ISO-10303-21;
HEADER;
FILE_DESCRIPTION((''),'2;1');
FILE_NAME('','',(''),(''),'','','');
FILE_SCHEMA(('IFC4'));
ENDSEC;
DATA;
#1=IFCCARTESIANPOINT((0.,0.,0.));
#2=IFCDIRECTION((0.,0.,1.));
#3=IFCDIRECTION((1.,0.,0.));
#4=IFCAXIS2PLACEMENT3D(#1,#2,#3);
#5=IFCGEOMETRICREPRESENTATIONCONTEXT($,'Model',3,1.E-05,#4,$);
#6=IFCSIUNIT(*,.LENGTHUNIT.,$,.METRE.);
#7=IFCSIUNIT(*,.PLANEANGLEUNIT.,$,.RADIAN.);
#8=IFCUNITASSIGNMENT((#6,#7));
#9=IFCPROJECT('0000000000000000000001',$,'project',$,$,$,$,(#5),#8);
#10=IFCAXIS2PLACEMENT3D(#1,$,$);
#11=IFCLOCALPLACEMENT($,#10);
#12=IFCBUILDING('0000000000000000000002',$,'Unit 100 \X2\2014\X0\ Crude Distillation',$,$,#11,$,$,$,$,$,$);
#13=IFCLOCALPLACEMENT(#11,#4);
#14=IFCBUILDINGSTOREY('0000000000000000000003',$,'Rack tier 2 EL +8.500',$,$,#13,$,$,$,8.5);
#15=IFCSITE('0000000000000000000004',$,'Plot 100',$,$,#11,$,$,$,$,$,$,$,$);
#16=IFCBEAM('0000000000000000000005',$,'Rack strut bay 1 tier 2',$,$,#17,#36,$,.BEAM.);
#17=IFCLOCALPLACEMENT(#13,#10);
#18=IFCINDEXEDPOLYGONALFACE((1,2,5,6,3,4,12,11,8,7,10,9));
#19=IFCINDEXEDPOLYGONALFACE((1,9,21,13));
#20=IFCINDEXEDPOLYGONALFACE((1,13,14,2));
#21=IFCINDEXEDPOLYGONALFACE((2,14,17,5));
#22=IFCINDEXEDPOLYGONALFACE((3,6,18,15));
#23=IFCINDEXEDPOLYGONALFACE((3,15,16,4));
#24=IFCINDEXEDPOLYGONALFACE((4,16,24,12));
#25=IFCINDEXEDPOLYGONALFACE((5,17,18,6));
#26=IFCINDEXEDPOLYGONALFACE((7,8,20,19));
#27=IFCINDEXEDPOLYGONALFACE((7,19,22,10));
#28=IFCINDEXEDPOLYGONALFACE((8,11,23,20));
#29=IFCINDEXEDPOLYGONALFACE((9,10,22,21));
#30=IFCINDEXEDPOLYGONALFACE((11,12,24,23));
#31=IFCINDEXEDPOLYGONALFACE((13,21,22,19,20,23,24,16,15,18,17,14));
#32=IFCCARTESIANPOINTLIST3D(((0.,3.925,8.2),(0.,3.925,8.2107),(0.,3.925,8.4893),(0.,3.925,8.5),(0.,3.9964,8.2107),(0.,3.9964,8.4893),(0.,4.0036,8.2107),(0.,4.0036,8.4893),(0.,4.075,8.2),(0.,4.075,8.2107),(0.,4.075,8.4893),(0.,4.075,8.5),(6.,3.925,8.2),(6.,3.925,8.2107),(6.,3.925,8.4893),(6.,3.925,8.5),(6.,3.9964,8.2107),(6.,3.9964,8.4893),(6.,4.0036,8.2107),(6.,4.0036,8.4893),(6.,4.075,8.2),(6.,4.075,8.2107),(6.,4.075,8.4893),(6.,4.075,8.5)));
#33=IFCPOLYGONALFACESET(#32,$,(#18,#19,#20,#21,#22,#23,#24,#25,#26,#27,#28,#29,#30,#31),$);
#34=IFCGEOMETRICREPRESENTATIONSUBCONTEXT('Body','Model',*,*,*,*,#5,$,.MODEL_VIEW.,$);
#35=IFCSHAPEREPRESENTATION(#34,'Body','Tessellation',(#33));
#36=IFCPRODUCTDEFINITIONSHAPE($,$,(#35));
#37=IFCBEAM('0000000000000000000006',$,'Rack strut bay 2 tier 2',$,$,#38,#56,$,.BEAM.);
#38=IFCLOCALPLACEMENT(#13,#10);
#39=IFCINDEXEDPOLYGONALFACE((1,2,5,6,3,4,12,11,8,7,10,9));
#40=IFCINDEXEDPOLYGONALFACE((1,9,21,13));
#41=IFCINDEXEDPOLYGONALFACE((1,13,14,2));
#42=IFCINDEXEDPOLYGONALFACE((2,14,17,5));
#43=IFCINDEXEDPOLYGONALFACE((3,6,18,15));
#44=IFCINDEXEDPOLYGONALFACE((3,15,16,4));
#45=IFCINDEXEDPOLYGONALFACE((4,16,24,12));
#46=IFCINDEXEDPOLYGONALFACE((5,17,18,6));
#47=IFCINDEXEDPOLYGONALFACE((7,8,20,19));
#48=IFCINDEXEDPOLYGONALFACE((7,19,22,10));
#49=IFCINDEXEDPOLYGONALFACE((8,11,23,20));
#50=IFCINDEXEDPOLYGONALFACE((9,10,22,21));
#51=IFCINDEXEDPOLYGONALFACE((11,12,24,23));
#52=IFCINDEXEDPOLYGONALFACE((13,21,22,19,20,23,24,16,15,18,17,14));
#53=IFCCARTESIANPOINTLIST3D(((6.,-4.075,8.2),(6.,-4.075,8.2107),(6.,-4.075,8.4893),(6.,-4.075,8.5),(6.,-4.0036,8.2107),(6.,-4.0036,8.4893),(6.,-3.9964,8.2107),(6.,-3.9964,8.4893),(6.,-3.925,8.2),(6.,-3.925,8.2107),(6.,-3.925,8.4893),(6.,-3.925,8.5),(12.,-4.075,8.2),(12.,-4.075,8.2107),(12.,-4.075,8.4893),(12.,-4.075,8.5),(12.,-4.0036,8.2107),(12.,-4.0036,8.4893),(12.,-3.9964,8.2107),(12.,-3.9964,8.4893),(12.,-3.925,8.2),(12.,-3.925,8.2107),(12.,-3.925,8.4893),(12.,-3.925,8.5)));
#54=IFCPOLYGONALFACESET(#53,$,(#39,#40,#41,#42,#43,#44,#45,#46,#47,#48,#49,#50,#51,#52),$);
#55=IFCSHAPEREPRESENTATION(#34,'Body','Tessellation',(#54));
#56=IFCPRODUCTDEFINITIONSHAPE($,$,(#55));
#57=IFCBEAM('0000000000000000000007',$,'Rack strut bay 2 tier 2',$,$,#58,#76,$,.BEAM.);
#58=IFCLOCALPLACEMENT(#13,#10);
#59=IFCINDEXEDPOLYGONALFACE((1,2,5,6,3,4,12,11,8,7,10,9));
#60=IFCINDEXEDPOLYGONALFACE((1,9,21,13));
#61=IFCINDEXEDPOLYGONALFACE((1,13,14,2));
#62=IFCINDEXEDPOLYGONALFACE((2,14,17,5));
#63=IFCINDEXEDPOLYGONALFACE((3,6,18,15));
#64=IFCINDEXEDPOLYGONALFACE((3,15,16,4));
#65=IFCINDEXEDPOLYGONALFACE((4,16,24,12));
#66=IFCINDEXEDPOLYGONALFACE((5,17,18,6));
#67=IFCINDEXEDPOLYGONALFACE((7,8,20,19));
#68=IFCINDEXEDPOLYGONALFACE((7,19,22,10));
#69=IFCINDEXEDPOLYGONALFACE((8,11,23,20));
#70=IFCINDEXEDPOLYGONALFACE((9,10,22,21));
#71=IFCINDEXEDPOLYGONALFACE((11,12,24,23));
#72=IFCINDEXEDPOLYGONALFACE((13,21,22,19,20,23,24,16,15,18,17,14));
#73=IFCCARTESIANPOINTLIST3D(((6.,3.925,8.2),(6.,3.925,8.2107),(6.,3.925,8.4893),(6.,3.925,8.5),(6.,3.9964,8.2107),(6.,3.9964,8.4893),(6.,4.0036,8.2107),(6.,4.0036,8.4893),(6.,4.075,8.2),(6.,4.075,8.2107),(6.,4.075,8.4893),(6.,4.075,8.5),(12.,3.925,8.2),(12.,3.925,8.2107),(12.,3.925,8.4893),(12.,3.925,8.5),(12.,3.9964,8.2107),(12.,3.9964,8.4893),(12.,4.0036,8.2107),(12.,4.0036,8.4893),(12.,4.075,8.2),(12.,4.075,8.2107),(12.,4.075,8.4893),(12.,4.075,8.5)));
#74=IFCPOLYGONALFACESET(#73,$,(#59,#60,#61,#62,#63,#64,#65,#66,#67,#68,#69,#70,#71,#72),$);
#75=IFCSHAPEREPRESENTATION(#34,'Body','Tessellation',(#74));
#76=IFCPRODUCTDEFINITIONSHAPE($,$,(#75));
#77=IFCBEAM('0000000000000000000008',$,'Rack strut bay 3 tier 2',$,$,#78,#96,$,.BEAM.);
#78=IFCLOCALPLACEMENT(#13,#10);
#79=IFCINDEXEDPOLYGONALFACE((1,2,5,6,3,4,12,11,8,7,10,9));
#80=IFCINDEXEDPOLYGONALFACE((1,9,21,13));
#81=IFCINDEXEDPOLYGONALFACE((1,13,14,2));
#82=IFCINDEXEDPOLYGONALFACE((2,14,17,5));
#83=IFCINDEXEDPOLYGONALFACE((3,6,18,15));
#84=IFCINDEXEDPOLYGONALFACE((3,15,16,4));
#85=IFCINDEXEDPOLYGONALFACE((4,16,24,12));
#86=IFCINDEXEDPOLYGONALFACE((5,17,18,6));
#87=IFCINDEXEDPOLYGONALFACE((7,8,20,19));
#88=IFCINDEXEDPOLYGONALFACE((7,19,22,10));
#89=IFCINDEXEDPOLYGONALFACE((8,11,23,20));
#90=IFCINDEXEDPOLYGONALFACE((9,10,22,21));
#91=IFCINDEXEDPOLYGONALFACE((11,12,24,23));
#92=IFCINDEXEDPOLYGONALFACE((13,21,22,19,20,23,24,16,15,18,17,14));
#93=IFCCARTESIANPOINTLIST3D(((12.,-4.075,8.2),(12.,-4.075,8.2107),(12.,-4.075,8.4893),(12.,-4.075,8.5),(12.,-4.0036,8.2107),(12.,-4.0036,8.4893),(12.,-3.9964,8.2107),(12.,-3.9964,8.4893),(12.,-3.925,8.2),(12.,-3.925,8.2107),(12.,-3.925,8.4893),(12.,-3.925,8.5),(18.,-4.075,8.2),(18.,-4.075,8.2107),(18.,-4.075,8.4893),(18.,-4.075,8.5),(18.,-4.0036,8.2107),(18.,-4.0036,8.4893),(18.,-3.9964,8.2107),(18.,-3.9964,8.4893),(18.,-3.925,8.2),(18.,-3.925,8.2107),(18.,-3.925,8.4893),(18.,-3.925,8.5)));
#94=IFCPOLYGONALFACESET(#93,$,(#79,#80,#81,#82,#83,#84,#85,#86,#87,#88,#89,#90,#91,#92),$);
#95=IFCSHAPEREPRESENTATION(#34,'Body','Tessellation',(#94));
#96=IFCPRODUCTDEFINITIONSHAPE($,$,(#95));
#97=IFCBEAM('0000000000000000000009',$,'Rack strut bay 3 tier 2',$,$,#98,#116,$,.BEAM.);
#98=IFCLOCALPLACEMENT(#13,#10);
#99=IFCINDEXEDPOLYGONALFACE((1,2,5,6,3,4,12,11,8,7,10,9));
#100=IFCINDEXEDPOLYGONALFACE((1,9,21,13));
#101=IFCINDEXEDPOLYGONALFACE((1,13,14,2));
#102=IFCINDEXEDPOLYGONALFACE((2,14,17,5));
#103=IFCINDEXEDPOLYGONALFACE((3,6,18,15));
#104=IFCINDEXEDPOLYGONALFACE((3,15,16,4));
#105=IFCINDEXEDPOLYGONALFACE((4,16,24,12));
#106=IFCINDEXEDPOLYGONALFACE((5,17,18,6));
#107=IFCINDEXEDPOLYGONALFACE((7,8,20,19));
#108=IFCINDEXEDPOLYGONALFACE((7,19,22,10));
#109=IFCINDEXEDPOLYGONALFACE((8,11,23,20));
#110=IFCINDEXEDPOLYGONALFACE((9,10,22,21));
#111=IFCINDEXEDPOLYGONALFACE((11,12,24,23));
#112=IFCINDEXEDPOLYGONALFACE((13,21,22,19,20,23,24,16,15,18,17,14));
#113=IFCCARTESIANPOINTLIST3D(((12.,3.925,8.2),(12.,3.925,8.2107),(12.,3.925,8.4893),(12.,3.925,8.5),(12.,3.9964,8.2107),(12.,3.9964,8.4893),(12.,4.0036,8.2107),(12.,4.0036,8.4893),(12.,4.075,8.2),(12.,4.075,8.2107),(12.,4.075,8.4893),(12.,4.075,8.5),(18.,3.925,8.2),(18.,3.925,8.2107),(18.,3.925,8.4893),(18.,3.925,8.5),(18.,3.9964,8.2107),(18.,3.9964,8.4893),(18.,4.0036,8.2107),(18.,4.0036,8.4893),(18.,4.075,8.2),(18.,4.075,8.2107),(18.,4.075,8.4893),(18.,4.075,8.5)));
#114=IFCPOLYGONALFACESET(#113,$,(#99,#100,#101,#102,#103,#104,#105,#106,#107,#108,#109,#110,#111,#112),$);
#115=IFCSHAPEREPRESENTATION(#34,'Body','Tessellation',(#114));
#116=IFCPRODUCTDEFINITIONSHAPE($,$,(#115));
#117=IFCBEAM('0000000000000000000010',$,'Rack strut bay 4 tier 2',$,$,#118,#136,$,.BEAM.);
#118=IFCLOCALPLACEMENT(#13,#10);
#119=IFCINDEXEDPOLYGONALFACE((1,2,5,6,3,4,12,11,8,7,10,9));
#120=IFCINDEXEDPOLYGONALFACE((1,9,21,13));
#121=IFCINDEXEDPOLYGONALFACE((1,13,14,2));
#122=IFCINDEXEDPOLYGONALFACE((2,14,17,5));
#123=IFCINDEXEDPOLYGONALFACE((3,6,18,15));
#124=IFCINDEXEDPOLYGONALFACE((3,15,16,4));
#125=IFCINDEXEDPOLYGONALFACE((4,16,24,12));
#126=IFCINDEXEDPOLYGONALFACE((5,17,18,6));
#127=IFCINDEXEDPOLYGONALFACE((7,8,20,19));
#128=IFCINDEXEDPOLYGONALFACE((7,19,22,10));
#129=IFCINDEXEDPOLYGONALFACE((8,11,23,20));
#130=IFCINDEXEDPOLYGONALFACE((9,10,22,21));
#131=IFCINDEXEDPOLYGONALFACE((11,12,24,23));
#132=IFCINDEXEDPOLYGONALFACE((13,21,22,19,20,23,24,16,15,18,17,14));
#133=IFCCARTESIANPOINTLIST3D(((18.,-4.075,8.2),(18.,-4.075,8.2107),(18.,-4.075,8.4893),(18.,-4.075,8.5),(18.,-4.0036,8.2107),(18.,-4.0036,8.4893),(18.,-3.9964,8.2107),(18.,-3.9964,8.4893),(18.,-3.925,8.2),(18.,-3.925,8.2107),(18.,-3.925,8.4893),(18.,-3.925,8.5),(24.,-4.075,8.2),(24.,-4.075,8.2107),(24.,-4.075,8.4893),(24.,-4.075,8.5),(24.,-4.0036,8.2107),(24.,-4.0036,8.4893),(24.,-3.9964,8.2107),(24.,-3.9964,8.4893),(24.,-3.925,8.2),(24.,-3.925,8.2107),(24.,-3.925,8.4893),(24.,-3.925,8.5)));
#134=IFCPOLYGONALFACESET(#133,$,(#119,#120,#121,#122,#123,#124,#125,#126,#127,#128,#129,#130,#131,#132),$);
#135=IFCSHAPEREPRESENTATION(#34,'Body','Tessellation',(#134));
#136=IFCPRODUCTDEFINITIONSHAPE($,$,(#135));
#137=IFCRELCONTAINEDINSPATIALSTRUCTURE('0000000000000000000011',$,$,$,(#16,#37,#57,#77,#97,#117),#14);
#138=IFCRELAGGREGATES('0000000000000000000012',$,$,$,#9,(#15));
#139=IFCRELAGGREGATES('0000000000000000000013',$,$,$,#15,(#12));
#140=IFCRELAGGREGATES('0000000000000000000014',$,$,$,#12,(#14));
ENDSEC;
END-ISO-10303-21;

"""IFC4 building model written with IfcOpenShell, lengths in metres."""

from ifc_helpers import new_model, si_unit, frame, origin, origin_with_axes, origin_2d, place, context, subcontext, project, spatial, i_section, extrude, element, save


model = new_model("IFC4")

# Units and contexts
model_context = context("Model", 3, precision=1e-05, world=origin_with_axes())
body_context = subcontext(model_context, "Body", "Model", "MODEL_VIEW")
ifc_project = project(units=[si_unit("LENGTHUNIT", "METRE"), si_unit("PLANEANGLEUNIT", "RADIAN")], contexts=[model_context])

# Site, building, storey
placement = place(None, origin())
site = spatial("IfcSite", under=ifc_project, at=placement, Name="Plot 100")
building = spatial("IfcBuilding", under=site, at=placement, Name="Unit 100 — Crude Distillation")
storey_placement = place(placement, origin_with_axes())
storey = spatial("IfcBuildingStorey", under=building, at=storey_placement, Name="Rack tier 2 EL +8.500", Elevation=8.5)

# Beams
beam_1_placement = place(storey_placement, origin_with_axes())
element("IfcBeam", 1, at=beam_1_placement, inside=storey, Name="Rack strut bay 1 tier 2", PredefinedType="BEAM", context=body_context, shape_type="SweptSolid", body=[
    extrude(i_section(OverallWidth=0.15, OverallDepth=0.3, WebThickness=0.0071, FlangeThickness=0.0107, at=origin_2d()), frame((0.0, 4.0, 8.35), z_axis=(1.0, 0.0, 0.0), x_axis=(0.0, 1.0, 0.0)), (0.0, 0.0, 1.0), 6.0),
])
beam_2_placement = place(storey_placement, origin_with_axes())
element("IfcBeam", 2, at=beam_2_placement, inside=storey, Name="Rack strut bay 2 tier 2", PredefinedType="BEAM", context=body_context, shape_type="SweptSolid", body=[
    extrude(i_section(OverallWidth=0.15, OverallDepth=0.3, WebThickness=0.0071, FlangeThickness=0.0107, at=origin_2d()), frame((6.0, -4.0, 8.35), z_axis=(1.0, 0.0, 0.0), x_axis=(0.0, 1.0, 0.0)), (0.0, 0.0, 1.0), 6.0),
])
beam_3_placement = place(storey_placement, origin_with_axes())
element("IfcBeam", 3, at=beam_3_placement, inside=storey, Name="Rack strut bay 2 tier 2", PredefinedType="BEAM", context=body_context, shape_type="SweptSolid", body=[
    extrude(i_section(OverallWidth=0.15, OverallDepth=0.3, WebThickness=0.0071, FlangeThickness=0.0107, at=origin_2d()), frame((6.0, 4.0, 8.35), z_axis=(1.0, 0.0, 0.0), x_axis=(0.0, 1.0, 0.0)), (0.0, 0.0, 1.0), 6.0),
])
beam_4_placement = place(storey_placement, origin_with_axes())
element("IfcBeam", 4, at=beam_4_placement, inside=storey, Name="Rack strut bay 3 tier 2", PredefinedType="BEAM", context=body_context, shape_type="SweptSolid", body=[
    extrude(i_section(OverallWidth=0.15, OverallDepth=0.3, WebThickness=0.0071, FlangeThickness=0.0107, at=origin_2d()), frame((12.0, -4.0, 8.35), z_axis=(1.0, 0.0, 0.0), x_axis=(0.0, 1.0, 0.0)), (0.0, 0.0, 1.0), 6.0),
])
beam_5_placement = place(storey_placement, origin_with_axes())
element("IfcBeam", 5, at=beam_5_placement, inside=storey, Name="Rack strut bay 3 tier 2", PredefinedType="BEAM", context=body_context, shape_type="SweptSolid", body=[
    extrude(i_section(OverallWidth=0.15, OverallDepth=0.3, WebThickness=0.0071, FlangeThickness=0.0107, at=origin_2d()), frame((12.0, 4.0, 8.35), z_axis=(1.0, 0.0, 0.0), x_axis=(0.0, 1.0, 0.0)), (0.0, 0.0, 1.0), 6.0),
])
beam_6_placement = place(storey_placement, origin_with_axes())
element("IfcBeam", 6, at=beam_6_placement, inside=storey, Name="Rack strut bay 4 tier 2", PredefinedType="BEAM", context=body_context, shape_type="SweptSolid", body=[
    extrude(i_section(OverallWidth=0.15, OverallDepth=0.3, WebThickness=0.0071, FlangeThickness=0.0107, at=origin_2d()), frame((18.0, -4.0, 8.35), z_axis=(1.0, 0.0, 0.0), x_axis=(0.0, 1.0, 0.0)), (0.0, 0.0, 1.0), 6.0),
])

save(model, "model.ifc")
